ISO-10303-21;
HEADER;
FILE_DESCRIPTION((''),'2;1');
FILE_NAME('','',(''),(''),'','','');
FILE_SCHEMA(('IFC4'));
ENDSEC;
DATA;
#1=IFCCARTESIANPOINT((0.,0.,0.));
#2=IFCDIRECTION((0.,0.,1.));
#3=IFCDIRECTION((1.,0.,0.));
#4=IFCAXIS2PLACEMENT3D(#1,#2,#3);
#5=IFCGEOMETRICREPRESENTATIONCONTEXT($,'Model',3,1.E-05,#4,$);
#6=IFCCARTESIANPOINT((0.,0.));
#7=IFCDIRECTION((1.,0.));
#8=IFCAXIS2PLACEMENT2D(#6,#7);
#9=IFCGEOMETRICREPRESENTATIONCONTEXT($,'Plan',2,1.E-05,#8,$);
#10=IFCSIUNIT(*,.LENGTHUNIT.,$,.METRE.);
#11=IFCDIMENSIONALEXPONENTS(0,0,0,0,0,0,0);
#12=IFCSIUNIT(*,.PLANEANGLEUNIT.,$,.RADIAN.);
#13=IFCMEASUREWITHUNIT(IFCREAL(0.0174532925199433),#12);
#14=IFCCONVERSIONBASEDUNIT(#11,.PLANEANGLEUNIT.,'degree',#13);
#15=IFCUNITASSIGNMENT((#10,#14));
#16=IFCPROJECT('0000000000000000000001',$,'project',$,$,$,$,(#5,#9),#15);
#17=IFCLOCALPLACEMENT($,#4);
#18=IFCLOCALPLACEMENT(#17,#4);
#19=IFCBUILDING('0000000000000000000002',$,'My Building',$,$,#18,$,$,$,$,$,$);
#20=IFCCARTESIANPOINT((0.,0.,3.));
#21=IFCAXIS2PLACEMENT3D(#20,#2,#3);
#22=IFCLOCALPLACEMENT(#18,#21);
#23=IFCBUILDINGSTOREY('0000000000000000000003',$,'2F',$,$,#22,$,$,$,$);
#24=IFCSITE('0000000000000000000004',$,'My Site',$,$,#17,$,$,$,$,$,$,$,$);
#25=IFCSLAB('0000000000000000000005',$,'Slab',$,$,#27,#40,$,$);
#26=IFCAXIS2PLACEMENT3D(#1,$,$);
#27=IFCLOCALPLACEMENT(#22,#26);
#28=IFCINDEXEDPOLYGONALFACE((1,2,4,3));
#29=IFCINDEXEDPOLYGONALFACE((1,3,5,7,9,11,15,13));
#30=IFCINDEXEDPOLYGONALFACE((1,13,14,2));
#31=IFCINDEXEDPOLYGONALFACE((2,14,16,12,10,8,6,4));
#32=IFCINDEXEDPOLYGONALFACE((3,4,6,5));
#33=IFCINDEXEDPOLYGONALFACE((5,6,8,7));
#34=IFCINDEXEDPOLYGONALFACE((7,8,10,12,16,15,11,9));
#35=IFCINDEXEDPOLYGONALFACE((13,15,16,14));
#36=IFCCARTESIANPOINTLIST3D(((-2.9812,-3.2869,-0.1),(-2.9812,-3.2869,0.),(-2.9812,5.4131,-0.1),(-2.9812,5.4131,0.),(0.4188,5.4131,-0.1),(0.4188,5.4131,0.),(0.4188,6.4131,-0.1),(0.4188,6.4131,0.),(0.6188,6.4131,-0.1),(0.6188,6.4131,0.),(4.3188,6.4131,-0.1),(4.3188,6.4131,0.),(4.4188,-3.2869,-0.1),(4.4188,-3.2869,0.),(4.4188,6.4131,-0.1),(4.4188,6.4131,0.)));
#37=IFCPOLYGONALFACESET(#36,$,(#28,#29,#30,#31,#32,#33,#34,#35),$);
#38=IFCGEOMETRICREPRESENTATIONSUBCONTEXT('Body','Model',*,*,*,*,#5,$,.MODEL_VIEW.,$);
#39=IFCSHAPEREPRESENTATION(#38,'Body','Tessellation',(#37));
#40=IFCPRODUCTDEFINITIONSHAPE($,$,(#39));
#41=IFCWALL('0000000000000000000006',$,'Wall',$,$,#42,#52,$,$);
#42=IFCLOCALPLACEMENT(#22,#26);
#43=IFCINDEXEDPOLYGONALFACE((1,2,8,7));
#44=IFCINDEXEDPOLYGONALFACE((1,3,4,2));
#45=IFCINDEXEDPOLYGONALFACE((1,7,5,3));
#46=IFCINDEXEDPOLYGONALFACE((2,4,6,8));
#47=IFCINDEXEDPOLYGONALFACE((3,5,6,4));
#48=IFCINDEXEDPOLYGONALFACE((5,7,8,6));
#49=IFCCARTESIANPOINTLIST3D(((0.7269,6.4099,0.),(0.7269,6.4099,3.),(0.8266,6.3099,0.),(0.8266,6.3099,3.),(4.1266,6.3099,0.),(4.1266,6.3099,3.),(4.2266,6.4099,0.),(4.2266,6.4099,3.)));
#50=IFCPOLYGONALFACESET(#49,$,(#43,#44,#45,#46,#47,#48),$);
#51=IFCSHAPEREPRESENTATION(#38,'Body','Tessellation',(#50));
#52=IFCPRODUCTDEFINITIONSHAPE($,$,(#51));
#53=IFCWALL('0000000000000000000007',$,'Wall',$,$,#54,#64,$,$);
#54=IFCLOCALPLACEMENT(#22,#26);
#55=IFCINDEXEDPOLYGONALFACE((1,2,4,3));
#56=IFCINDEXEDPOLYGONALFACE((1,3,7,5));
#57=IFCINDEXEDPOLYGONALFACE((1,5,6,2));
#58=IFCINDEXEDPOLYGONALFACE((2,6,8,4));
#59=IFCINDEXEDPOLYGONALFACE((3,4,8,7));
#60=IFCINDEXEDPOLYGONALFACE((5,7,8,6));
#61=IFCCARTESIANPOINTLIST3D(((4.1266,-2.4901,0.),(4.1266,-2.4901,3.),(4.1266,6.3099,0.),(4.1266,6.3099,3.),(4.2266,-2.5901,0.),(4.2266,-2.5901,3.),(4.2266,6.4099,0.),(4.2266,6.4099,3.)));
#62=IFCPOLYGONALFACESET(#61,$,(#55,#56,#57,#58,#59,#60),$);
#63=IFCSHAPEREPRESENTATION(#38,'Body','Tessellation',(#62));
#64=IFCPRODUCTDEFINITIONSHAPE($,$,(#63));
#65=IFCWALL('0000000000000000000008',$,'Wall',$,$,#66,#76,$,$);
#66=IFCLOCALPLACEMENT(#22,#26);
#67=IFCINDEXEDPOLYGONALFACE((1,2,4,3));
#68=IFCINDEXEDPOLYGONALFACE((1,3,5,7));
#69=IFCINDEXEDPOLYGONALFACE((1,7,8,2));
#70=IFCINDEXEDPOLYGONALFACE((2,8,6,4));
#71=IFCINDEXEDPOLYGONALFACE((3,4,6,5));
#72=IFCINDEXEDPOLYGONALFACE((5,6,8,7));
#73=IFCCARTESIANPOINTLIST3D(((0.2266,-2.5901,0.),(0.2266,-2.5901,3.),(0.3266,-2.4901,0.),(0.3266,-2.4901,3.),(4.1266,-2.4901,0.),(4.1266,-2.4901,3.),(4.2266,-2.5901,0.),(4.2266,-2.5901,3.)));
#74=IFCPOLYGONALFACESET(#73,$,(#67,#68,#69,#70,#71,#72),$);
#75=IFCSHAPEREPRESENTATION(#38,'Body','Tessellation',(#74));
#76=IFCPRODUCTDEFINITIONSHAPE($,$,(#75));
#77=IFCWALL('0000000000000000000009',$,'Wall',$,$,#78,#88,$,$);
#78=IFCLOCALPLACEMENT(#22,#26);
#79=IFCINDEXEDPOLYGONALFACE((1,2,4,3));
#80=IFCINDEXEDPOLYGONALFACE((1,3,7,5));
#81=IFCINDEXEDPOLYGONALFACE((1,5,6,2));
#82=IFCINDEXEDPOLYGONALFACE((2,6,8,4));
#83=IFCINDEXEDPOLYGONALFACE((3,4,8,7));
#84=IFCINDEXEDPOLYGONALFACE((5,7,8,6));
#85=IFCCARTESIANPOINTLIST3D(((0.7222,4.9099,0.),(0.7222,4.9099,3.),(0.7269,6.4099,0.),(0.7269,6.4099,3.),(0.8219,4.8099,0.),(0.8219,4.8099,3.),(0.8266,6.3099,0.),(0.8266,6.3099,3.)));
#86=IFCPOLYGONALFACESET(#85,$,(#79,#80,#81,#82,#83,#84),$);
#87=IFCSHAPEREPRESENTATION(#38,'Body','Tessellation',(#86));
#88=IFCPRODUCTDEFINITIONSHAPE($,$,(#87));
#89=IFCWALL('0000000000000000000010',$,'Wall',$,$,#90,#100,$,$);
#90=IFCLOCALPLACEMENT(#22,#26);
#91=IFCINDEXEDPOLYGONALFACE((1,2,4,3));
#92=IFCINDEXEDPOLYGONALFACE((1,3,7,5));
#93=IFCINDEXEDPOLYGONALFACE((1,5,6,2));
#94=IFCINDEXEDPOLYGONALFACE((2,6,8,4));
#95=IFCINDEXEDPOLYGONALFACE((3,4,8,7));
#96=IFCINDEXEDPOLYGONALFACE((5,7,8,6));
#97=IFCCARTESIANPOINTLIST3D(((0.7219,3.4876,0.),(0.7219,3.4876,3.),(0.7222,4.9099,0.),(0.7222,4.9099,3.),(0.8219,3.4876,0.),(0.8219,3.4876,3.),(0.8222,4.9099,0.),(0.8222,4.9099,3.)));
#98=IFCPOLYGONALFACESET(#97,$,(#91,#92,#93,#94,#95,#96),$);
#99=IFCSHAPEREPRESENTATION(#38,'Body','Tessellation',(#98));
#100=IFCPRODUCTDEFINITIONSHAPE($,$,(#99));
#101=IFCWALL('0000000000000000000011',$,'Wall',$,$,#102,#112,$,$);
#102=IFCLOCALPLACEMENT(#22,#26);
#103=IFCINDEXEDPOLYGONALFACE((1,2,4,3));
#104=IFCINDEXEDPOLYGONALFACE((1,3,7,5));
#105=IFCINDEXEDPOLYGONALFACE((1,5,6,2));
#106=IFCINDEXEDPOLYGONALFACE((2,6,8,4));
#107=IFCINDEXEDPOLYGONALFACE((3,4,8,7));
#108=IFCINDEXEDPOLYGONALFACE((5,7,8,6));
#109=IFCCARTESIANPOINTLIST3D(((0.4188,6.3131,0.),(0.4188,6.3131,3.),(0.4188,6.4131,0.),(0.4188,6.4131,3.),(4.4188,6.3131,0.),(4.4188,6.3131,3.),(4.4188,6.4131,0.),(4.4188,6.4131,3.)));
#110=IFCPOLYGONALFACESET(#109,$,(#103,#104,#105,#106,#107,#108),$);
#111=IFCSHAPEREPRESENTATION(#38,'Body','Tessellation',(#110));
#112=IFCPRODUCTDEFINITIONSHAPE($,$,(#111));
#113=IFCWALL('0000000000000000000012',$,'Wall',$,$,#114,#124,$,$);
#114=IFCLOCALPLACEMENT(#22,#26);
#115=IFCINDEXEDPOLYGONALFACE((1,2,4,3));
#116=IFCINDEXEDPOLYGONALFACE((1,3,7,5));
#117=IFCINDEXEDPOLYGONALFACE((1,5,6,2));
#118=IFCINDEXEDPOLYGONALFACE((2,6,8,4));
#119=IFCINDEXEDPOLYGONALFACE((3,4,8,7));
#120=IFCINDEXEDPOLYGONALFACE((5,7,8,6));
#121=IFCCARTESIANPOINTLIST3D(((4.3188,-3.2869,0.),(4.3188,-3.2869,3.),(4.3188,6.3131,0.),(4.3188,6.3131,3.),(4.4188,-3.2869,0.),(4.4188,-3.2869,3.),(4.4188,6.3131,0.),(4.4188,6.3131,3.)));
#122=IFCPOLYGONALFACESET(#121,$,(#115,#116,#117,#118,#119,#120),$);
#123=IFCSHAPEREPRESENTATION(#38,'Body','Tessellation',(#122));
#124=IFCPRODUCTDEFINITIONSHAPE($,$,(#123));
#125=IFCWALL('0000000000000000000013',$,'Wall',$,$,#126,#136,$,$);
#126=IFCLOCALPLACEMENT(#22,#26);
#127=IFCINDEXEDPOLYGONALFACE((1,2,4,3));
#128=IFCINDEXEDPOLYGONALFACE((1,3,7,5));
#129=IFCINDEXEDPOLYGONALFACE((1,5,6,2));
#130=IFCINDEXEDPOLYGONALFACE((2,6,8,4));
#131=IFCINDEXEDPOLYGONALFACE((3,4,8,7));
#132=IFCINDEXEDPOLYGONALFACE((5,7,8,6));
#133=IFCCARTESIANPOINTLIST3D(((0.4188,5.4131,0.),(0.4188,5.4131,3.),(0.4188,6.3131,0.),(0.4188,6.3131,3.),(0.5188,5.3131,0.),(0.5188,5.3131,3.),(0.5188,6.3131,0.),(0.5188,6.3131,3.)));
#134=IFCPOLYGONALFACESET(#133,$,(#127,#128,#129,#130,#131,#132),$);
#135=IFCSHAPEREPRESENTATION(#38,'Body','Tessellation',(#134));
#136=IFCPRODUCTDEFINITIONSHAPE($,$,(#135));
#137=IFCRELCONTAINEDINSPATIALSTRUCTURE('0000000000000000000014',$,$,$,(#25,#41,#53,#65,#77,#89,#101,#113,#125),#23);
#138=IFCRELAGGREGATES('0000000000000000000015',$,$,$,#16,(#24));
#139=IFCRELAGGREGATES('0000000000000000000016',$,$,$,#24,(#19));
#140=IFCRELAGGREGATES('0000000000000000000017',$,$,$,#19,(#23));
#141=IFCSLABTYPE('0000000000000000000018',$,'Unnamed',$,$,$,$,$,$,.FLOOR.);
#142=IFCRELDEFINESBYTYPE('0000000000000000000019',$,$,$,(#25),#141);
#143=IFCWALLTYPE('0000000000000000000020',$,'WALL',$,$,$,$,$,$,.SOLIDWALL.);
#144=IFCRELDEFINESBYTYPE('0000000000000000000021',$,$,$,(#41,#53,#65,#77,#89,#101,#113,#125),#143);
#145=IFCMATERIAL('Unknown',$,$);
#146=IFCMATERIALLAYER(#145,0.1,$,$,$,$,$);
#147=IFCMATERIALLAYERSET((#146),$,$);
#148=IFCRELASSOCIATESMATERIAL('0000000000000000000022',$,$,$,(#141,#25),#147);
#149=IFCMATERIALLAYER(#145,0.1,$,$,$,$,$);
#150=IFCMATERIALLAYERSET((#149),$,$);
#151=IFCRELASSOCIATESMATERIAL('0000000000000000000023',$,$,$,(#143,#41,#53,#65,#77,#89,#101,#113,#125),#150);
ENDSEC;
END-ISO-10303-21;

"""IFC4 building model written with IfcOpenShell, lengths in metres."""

from ifc_helpers import new_model, entity, si_unit, converted_unit, frame, origin_with_axes, origin_2d_with_axis, place, context, subcontext, project, spatial, line, indexed_curve, outline, extrude, material, layer, layer_set, layer_usage, type_object, element, save


model = new_model("IFC4")

# Units and contexts
model_context = context("Model", 3, precision=1e-05, world=origin_with_axes())
plan_context = context("Plan", 2, precision=1e-05, world=origin_2d_with_axis())
body_context_1 = subcontext(model_context, "Body", "Model", "MODEL_VIEW")
ifc_project = project(units=[si_unit("LENGTHUNIT", "METRE"), converted_unit("PLANEANGLEUNIT", "degree", entity("IfcReal", 0.0174532925199433), si_unit("PLANEANGLEUNIT", "RADIAN"), dimensions=[0, 0, 0, 0, 0, 0, 0])], contexts=[model_context, plan_context])

# Site, building, storey
site_placement = place(None, origin_with_axes())
site = spatial("IfcSite", under=ifc_project, at=site_placement, Name="My Site")
building_placement = place(site_placement, origin_with_axes())
building = spatial("IfcBuilding", under=site, at=building_placement, Name="My Building")
storey_placement = place(building_placement, frame((0.0, 0.0, 3.0), z_axis=(0.0, 0.0, 1.0), x_axis=(1.0, 0.0, 0.0)))
storey = spatial("IfcBuildingStorey", under=building, at=storey_placement, Name="2F")

# Slab
ifc_material = material(Name="Unknown")
ifc_layer_1 = layer(ifc_material, 0.1)
ifc_layer_set_1 = layer_set([ifc_layer_1])
ifc_layer_usage_1 = layer_usage(ifc_layer_set_1, "AXIS3", "POSITIVE", -0.1)
slab_type = type_object("IfcSlabType", Name="Unnamed", PredefinedType="FLOOR", material=ifc_layer_set_1)
slab_placement = place(storey_placement, frame((0.6188, 6.4131, 0.0), z_axis=(0.0, 0.0, 1.0), x_axis=(1.0, 0.0, 0.0)))
element("IfcSlab", 1, at=slab_placement, inside=storey, type_object=slab_type, material=ifc_layer_usage_1, Name="Slab", context=body_context_1, shape_type="SweptSolid", body=[
    extrude(outline(indexed_curve([(0.0, 0.0), (3.7, 0.0), (3.8, 0.0), (3.8, -9.7), (-3.6, -9.7), (-3.6, -1.0), (-0.2, -1.0), (-0.2, 0.0), (0.0, 0.0)])), frame((0.0, 0.0, -0.1), z_axis=(0.0, 0.0, 1.0), x_axis=(1.0, 0.0, 0.0)), (0.0, 0.0, 1.0), 0.1),
])

# Walls
ifc_layer_2 = layer(ifc_material, 0.1)
ifc_layer_set_2 = layer_set([ifc_layer_2])
ifc_layer_usage_2 = layer_usage(ifc_layer_set_2, "AXIS2", "POSITIVE", 0.0)
wall_type = type_object("IfcWallType", Name="WALL", PredefinedType="SOLIDWALL", material=ifc_layer_set_2)
wall_1_placement = place(storey_placement, frame((0.8266, 6.3099, 0.0), z_axis=(0.0, 0.0, 1.0), x_axis=(1.0, 0.0, 0.0)))
element("IfcWall", 2, at=wall_1_placement, inside=storey, type_object=wall_type, material=ifc_layer_usage_2, Name="Wall", context=body_context_1, shape_type="SweptSolid", body=[
    extrude(outline(indexed_curve([(0.0, 0.0), (-0.0997, 0.1), (3.4, 0.1), (3.3, 0.0)], segments=[line(1, 2, 3, 4, 1)])), origin_with_axes(), (0.0, 0.0, 1.0), 3.0),
])
ifc_layer_usage_3 = layer_usage(ifc_layer_set_2, "AXIS2", "POSITIVE", 0.0)
wall_2_placement = place(storey_placement, frame((4.1266, 6.3099, 0.0), z_axis=(0.0, 0.0, 1.0), x_axis=(0.0, -1.0, 0.0)))
element("IfcWall", 3, at=wall_2_placement, inside=storey, type_object=wall_type, material=ifc_layer_usage_3, Name="Wall", context=body_context_1, shape_type="SweptSolid", body=[
    extrude(outline(indexed_curve([(0.0, 0.0), (-0.1, 0.1), (8.9, 0.1), (8.8, 0.0)], segments=[line(1, 2, 3, 4, 1)])), origin_with_axes(), (0.0, 0.0, 1.0), 3.0),
])
ifc_layer_usage_4 = layer_usage(ifc_layer_set_2, "AXIS2", "POSITIVE", 0.0)
wall_3_placement = place(storey_placement, frame((4.1266, -2.4901, 0.0), z_axis=(0.0, 0.0, 1.0), x_axis=(-1.0, 0.0, 0.0)))
element("IfcWall", 4, at=wall_3_placement, inside=storey, type_object=wall_type, material=ifc_layer_usage_4, Name="Wall", context=body_context_1, shape_type="SweptSolid", body=[
    extrude(outline(indexed_curve([(0.0, 0.0), (-0.1, 0.1), (3.9, 0.1), (3.8, 0.0)], segments=[line(1, 2, 3, 4, 1)])), origin_with_axes(), (0.0, 0.0, 1.0), 3.0),
])
ifc_layer_usage_5 = layer_usage(ifc_layer_set_2, "AXIS2", "POSITIVE", 0.0)
wall_4_placement = place(storey_placement, frame((0.8219, 4.8099, 0.0), z_axis=(0.0, 0.0, 1.0), x_axis=(0.003117, 0.999995, 0.0)))
element("IfcWall", 5, at=wall_4_placement, inside=storey, type_object=wall_type, material=ifc_layer_usage_5, Name="Wall", context=body_context_1, shape_type="SweptSolid", body=[
    extrude(outline(indexed_curve([(0.0, 0.0), (0.0997, 0.1), (1.5997, 0.1), (1.5, 0.0)], segments=[line(1, 2, 3, 4, 1)])), origin_with_axes(), (0.0, 0.0, 1.0), 3.0),
])
ifc_layer_usage_6 = layer_usage(ifc_layer_set_2, "AXIS2", "POSITIVE", 0.0)
wall_5_placement = place(storey_placement, frame((0.7222, 4.9099, 0.0), z_axis=(0.0, 0.0, 1.0), x_axis=(-0.000219, -1.0, 0.0)))
element("IfcWall", 6, at=wall_5_placement, inside=storey, type_object=wall_type, material=ifc_layer_usage_6, Name="Wall", context=body_context_1, shape_type="SweptSolid", body=[
    extrude(outline(indexed_curve([(0.0, 0.0), (0.0, 0.1), (1.4223, 0.1), (1.4223, 0.0)], segments=[line(1, 2, 3, 4, 1)])), origin_with_axes(), (0.0, 0.0, 1.0), 3.0),
])
ifc_layer_usage_7 = layer_usage(ifc_layer_set_2, "AXIS2", "POSITIVE", 0.0)
wall_6_placement = place(storey_placement, frame((0.4188, 6.3131, 0.0), z_axis=(0.0, 0.0, 1.0), x_axis=(1.0, 0.0, 0.0)))
element("IfcWall", 7, at=wall_6_placement, inside=storey, type_object=wall_type, material=ifc_layer_usage_7, Name="Wall", context=body_context_1, shape_type="SweptSolid", body=[
    extrude(outline(indexed_curve([(0.0, 0.0), (0.0, 0.1), (4.0, 0.1), (4.0, 0.0)], segments=[line(1, 2, 3, 4, 1)])), origin_with_axes(), (0.0, 0.0, 1.0), 3.0),
])
ifc_layer_usage_8 = layer_usage(ifc_layer_set_2, "AXIS2", "POSITIVE", 0.0)
wall_7_placement = place(storey_placement, frame((4.3188, 6.3131, 0.0), z_axis=(0.0, 0.0, 1.0), x_axis=(0.0, -1.0, 0.0)))
element("IfcWall", 8, at=wall_7_placement, inside=storey, type_object=wall_type, material=ifc_layer_usage_8, Name="Wall", context=body_context_1, shape_type="SweptSolid", body=[
    extrude(outline(indexed_curve([(0.0, 0.0), (0.0, 0.1), (9.6, 0.1), (9.6, 0.0)], segments=[line(1, 2, 3, 4, 1)])), origin_with_axes(), (0.0, 0.0, 1.0), 3.0),
])
ifc_layer_usage_9 = layer_usage(ifc_layer_set_2, "AXIS2", "POSITIVE", 0.0)
wall_8_placement = place(storey_placement, frame((0.4188, 6.3131, 0.0), z_axis=(0.0, 0.0, 1.0), x_axis=(0.0, -1.0, 0.0)))
element("IfcWall", 9, at=wall_8_placement, inside=storey, type_object=wall_type, material=ifc_layer_usage_9, Name="Wall", context=body_context_1, shape_type="SweptSolid", body=[
    extrude(outline(indexed_curve([(0.0, 0.0), (0.0, 0.1), (1.0, 0.1), (0.9, 0.0)], segments=[line(1, 2, 3, 4, 1)])), origin_with_axes(), (0.0, 0.0, 1.0), 3.0),
])

save(model, "model.ifc")
